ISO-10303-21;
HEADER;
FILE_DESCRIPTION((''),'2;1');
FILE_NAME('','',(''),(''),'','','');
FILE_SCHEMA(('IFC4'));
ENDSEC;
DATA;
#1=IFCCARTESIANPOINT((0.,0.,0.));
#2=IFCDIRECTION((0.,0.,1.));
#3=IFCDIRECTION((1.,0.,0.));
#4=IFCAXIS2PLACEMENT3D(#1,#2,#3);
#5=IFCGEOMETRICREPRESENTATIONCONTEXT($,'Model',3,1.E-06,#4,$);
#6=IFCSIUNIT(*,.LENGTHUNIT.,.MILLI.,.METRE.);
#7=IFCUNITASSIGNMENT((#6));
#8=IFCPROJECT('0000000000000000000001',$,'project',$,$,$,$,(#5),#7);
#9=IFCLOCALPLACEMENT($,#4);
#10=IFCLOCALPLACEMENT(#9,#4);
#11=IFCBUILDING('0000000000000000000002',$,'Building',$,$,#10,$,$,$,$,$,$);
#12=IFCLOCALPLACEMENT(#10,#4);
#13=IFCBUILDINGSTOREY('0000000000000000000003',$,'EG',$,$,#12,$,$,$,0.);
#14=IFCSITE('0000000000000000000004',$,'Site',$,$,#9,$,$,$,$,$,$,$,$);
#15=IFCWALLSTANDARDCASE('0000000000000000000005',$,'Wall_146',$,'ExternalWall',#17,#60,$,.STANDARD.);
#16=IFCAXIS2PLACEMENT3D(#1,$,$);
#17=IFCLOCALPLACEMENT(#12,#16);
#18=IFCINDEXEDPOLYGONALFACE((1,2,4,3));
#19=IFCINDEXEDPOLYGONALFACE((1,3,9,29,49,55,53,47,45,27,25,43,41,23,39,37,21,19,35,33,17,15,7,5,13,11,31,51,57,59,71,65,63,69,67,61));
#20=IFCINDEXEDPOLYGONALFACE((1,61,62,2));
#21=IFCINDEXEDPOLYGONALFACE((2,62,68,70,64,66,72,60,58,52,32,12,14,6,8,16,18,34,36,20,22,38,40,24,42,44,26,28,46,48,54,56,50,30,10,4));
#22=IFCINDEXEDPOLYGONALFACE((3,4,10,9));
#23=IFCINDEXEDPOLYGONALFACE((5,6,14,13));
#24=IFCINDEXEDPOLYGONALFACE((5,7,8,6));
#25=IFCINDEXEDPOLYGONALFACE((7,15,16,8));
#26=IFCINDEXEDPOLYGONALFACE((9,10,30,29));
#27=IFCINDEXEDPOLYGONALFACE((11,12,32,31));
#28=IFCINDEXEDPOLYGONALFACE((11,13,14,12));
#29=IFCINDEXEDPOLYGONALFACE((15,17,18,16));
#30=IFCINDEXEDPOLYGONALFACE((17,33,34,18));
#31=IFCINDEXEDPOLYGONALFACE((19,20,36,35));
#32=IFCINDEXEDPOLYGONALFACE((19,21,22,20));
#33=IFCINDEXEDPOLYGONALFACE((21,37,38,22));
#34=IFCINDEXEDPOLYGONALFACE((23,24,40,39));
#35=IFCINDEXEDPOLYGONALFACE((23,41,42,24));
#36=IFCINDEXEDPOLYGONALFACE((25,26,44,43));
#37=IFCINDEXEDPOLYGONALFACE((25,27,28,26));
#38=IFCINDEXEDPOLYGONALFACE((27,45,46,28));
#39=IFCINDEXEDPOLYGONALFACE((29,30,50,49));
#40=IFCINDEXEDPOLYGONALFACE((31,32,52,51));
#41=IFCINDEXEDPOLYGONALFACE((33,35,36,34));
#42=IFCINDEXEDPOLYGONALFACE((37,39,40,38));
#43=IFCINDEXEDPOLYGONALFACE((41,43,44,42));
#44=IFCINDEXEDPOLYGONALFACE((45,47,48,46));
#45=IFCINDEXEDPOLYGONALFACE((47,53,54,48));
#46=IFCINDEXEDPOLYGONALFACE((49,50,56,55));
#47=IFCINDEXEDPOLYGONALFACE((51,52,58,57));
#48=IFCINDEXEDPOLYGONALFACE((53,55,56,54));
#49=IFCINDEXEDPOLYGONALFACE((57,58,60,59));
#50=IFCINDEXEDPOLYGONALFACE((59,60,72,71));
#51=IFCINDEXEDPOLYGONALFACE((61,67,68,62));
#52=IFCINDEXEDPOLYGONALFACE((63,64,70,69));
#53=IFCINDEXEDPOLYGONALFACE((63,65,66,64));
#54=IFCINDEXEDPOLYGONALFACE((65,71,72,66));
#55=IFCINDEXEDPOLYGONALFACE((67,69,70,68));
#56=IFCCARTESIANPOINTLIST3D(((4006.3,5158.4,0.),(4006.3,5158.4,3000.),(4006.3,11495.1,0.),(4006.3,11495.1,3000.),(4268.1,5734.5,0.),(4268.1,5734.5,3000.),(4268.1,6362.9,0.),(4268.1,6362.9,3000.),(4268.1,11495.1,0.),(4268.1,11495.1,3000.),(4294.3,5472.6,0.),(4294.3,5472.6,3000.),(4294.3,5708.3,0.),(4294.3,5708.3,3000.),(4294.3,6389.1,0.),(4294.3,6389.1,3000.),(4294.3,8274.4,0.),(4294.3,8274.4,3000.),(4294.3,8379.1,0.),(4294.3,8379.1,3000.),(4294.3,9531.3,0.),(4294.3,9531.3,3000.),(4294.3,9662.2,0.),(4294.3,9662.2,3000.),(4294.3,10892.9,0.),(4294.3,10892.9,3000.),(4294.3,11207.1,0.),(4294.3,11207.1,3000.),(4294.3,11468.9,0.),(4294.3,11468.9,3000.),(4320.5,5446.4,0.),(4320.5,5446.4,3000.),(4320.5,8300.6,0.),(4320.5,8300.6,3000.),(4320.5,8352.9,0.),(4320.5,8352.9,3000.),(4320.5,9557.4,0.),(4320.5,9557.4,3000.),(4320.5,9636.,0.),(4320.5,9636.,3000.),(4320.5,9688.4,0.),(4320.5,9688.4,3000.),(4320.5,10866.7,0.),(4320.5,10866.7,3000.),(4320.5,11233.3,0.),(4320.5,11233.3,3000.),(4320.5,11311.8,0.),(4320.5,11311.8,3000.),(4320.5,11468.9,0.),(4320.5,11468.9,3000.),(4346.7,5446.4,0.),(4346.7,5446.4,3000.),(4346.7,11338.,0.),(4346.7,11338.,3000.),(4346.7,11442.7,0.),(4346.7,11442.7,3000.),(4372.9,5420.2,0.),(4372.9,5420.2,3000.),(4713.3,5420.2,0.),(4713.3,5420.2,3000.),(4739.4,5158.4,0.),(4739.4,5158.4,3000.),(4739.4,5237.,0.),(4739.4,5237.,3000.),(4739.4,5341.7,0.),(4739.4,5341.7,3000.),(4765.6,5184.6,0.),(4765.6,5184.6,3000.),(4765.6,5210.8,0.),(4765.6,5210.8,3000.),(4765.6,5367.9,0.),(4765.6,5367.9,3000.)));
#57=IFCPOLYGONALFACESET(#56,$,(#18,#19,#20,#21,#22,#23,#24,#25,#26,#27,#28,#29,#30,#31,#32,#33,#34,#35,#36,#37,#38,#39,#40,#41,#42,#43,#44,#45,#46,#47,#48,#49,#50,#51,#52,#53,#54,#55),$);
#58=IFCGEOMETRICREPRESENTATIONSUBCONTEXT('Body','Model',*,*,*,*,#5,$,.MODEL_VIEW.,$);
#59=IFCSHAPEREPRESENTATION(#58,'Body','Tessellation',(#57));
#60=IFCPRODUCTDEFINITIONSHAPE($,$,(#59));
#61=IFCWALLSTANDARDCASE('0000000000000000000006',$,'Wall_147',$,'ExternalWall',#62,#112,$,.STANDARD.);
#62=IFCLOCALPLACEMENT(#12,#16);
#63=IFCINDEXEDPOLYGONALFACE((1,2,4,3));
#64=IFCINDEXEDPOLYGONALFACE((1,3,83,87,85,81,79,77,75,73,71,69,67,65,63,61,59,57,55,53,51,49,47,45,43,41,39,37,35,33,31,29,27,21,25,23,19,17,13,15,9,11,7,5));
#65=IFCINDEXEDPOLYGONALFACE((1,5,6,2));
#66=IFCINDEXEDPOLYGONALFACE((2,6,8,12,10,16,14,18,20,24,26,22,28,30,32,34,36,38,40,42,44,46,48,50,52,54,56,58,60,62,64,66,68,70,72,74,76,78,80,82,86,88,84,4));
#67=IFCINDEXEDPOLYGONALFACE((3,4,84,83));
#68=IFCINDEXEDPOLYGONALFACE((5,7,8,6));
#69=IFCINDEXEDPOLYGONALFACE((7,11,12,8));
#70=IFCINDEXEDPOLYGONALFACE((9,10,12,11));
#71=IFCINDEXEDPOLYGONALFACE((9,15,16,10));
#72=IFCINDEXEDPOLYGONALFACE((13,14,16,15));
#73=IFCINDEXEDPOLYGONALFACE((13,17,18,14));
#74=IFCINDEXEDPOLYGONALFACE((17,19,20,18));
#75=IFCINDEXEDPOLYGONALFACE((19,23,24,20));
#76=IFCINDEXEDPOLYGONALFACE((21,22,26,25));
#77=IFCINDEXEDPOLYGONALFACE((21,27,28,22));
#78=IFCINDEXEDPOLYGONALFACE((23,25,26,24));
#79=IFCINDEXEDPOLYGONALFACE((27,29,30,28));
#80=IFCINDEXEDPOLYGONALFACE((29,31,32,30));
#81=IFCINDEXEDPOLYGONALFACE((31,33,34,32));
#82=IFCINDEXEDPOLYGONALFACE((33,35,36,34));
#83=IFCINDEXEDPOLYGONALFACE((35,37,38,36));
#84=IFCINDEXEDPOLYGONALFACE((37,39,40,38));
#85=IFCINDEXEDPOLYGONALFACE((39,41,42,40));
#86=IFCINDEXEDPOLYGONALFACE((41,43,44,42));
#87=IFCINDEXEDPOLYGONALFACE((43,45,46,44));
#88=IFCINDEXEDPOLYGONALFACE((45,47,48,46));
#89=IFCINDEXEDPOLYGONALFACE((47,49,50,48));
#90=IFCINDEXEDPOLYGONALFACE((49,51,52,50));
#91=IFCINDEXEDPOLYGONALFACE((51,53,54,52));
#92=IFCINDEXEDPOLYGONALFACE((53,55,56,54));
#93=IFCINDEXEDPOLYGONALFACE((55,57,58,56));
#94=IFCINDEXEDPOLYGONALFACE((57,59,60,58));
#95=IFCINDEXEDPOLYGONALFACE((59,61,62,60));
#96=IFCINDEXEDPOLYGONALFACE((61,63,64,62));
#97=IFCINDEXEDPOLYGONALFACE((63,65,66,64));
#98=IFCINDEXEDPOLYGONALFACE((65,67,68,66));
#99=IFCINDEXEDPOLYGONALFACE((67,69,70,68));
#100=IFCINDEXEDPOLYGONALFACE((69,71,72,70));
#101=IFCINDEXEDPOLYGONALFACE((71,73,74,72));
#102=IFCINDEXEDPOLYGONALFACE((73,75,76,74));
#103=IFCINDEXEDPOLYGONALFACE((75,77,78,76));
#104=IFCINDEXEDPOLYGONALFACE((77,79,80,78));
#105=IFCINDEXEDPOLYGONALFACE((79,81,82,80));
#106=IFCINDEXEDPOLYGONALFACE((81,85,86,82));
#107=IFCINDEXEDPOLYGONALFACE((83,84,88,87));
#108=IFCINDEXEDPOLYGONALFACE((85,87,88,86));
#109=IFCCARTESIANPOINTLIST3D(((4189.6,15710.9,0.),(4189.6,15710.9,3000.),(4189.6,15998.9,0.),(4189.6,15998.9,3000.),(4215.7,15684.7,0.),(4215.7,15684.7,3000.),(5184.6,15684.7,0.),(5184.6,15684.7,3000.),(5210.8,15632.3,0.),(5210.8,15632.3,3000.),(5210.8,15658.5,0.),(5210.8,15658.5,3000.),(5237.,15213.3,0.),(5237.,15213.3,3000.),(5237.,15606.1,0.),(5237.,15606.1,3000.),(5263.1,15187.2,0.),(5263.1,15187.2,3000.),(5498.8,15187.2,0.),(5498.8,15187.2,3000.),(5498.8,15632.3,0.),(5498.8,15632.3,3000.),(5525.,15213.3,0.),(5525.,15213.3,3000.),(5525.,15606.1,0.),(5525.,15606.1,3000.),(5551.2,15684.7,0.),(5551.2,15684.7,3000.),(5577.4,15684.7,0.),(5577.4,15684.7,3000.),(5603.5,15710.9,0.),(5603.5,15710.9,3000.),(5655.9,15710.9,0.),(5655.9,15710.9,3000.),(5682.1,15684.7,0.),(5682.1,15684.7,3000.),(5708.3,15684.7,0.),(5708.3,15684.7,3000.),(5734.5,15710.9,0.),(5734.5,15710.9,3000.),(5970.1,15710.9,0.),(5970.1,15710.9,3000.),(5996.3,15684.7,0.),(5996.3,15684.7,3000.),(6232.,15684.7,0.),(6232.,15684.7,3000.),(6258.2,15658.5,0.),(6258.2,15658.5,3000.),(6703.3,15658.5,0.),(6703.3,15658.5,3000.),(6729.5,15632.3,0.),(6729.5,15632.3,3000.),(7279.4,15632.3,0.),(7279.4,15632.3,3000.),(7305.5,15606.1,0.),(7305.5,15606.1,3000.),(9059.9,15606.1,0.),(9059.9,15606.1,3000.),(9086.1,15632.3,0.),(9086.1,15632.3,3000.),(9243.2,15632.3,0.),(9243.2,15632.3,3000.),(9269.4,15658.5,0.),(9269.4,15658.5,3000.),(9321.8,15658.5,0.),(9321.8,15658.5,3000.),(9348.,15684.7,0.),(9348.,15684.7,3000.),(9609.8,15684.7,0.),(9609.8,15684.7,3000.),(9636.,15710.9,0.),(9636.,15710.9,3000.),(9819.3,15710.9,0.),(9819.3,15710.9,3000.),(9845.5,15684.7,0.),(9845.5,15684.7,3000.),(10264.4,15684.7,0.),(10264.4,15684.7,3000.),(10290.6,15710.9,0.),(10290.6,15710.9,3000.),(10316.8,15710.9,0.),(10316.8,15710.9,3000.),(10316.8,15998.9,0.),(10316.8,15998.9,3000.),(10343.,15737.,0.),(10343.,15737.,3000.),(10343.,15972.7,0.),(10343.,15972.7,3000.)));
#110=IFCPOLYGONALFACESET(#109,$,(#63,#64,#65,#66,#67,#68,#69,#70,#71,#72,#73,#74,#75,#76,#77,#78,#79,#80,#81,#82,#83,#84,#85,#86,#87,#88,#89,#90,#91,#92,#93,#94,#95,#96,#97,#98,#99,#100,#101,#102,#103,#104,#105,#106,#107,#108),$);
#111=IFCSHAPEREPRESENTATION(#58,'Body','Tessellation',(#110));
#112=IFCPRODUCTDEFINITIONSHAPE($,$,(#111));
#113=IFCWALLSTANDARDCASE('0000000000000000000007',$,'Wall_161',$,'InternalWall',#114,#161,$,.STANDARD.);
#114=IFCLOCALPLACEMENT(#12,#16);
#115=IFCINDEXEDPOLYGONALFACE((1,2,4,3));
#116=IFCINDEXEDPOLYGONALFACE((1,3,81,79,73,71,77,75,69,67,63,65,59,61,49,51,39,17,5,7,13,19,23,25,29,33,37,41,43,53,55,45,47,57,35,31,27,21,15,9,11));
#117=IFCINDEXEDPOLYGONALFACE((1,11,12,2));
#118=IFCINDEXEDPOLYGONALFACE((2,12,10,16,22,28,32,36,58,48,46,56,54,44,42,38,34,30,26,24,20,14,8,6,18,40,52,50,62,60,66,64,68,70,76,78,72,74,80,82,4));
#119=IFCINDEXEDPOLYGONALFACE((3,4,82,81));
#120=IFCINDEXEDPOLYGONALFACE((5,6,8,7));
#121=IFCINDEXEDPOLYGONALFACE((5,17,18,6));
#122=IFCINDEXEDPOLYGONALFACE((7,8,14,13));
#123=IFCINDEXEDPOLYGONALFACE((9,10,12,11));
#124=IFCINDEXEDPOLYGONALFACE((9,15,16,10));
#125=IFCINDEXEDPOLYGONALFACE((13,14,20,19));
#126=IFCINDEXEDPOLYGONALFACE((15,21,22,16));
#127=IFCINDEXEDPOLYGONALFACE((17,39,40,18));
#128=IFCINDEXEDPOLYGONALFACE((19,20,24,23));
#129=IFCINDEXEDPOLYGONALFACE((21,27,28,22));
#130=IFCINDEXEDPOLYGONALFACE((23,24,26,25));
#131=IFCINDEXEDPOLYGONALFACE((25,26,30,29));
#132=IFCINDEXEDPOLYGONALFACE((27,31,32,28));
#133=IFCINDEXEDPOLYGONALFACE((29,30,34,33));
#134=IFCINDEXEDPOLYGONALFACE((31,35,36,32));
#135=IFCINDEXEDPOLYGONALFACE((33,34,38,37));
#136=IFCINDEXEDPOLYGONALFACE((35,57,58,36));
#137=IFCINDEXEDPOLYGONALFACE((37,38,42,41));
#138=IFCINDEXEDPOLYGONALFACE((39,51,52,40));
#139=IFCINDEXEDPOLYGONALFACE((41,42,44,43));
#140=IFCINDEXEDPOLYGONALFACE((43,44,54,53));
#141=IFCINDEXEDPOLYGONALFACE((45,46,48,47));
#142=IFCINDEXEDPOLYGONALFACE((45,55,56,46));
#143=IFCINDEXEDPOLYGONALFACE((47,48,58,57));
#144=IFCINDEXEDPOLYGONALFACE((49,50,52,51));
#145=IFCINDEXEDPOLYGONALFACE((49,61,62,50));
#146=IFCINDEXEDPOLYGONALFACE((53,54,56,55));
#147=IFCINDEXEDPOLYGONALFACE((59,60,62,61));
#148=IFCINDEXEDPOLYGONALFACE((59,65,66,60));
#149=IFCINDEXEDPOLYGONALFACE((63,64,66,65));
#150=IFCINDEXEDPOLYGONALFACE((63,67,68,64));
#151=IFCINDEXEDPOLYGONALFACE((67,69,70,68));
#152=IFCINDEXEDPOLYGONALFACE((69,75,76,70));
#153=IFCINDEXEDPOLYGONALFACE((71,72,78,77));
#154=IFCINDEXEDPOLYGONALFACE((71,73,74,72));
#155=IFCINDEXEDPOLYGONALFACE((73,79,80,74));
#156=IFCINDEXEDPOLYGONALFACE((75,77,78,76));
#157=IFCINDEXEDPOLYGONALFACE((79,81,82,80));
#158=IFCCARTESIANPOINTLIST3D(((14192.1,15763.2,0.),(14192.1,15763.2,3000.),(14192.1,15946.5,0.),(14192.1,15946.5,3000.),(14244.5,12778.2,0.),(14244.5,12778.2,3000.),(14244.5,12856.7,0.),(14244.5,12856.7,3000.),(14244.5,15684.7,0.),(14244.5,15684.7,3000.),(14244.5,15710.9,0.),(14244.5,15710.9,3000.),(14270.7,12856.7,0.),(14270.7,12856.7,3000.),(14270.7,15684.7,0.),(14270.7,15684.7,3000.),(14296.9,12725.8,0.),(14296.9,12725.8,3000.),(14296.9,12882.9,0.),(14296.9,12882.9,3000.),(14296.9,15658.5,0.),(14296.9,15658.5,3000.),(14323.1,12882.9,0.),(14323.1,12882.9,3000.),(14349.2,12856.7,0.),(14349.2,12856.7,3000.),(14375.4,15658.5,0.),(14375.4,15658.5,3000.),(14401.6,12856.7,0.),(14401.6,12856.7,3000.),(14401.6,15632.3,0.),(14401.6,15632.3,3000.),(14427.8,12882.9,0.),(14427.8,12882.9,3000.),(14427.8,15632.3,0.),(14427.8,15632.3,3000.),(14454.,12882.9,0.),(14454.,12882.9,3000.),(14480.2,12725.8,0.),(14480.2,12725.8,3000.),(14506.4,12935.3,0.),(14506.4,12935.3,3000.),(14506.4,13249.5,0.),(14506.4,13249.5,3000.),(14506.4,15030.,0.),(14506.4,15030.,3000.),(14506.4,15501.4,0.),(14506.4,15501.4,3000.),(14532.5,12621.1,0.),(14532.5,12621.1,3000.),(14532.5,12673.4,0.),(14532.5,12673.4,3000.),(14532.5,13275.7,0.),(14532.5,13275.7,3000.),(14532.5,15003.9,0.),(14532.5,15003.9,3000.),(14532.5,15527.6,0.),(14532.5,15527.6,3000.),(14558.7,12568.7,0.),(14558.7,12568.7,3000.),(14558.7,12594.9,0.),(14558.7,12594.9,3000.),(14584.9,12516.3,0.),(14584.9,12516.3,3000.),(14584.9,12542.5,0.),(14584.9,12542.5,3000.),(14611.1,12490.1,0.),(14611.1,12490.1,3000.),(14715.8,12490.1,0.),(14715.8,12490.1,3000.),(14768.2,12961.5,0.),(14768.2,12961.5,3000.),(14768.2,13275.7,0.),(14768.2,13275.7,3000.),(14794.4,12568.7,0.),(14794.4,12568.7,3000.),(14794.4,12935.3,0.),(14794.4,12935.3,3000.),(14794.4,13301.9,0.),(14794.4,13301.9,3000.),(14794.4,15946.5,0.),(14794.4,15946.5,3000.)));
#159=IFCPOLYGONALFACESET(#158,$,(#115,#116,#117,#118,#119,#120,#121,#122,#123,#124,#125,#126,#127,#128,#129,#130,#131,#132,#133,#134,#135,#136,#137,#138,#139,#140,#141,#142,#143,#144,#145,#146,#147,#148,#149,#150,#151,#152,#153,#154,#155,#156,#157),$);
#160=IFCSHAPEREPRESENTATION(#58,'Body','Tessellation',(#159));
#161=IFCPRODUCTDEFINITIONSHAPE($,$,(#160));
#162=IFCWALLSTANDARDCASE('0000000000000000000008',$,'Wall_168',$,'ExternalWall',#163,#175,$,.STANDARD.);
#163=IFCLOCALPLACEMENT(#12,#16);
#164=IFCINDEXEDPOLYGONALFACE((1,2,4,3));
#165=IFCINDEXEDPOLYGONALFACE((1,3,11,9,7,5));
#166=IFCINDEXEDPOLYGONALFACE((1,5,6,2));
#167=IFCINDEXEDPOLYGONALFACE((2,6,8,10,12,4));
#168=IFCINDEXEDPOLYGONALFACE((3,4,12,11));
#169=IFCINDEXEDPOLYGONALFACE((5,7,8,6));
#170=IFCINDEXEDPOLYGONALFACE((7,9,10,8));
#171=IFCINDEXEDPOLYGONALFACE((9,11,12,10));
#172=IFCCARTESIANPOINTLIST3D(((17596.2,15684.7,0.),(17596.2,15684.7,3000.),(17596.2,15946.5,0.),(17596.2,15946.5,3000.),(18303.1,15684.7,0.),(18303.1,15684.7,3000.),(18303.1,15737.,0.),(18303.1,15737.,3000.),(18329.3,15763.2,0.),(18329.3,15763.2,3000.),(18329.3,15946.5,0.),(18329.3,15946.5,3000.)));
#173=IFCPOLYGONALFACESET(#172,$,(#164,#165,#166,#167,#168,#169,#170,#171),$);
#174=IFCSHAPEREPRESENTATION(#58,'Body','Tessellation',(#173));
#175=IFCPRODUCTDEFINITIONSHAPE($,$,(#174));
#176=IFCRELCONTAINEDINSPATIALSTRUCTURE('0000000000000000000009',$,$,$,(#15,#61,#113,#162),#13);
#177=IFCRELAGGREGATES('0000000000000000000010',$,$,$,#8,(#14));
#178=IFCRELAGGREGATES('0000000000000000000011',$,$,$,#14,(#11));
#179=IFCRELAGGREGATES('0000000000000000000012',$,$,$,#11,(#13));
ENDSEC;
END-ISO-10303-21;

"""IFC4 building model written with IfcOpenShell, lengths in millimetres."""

from ifc_helpers import new_model, si_unit, frame, origin_with_axes, place, context, subcontext, project, spatial, polyline, outline, extrude, element, save


model = new_model("IFC4")

# Units and contexts
model_context = context("Model", 3, precision=1e-06, world=origin_with_axes())
body_context = subcontext(model_context, "Body", "Model", "MODEL_VIEW")
ifc_project = project(units=[si_unit("LENGTHUNIT", "METRE", prefix="MILLI")], contexts=[model_context])

# Site, building, storey
site_placement = place(None, origin_with_axes())
site = spatial("IfcSite", under=ifc_project, at=site_placement, Name="Site")
building_placement = place(site_placement, origin_with_axes())
building = spatial("IfcBuilding", under=site, at=building_placement, Name="Building")
storey_placement = place(building_placement, origin_with_axes())
storey = spatial("IfcBuildingStorey", under=building, at=storey_placement, Name="EG", Elevation=0.0)

# Walls
wall_1_placement = place(storey_placement, origin_with_axes())
element("IfcWallStandardCase", 1, at=wall_1_placement, inside=storey, Name="Wall_146", ObjectType="ExternalWall", PredefinedType="STANDARD", context=body_context, shape_type="SweptSolid", body=[
    extrude(outline(polyline([(4006.3, 5158.4, 0.0), (4006.3, 11495.1, 0.0), (4268.1, 11495.1, 0.0), (4294.3, 11468.9, 0.0), (4320.5, 11468.9, 0.0), (4346.7, 11442.7, 0.0), (4346.7, 11338.0, 0.0), (4320.5, 11311.8, 0.0), (4320.5, 11233.3, 0.0), (4294.3, 11207.1, 0.0), (4294.3, 10892.9, 0.0), (4320.5, 10866.7, 0.0), (4320.5, 9688.4, 0.0), (4294.3, 9662.2, 0.0), (4320.5, 9636.0, 0.0), (4320.5, 9557.4, 0.0), (4294.3, 9531.3, 0.0), (4294.3, 8379.1, 0.0), (4320.5, 8352.9, 0.0), (4320.5, 8300.6, 0.0), (4294.3, 8274.4, 0.0), (4294.3, 6389.1, 0.0), (4268.1, 6362.9, 0.0), (4268.1, 5734.5, 0.0), (4294.3, 5708.3, 0.0), (4294.3, 5472.6, 0.0), (4320.5, 5446.4, 0.0), (4346.7, 5446.4, 0.0), (4372.9, 5420.2, 0.0), (4713.3, 5420.2, 0.0), (4765.6, 5367.9, 0.0), (4739.4, 5341.7, 0.0), (4739.4, 5237.0, 0.0), (4765.6, 5210.8, 0.0), (4765.6, 5184.6, 0.0), (4739.4, 5158.4, 0.0), (4006.3, 5158.4, 0.0)])), origin_with_axes(), (0.0, 0.0, 1.0), 3000.0),
])
wall_2_placement = place(storey_placement, origin_with_axes())
element("IfcWallStandardCase", 2, at=wall_2_placement, inside=storey, Name="Wall_147", ObjectType="ExternalWall", PredefinedType="STANDARD", context=body_context, shape_type="SweptSolid", body=[
    extrude(outline(polyline([(5263.1, 15187.2, 0.0), (5237.0, 15213.3, 0.0), (5237.0, 15606.1, 0.0), (5210.8, 15632.3, 0.0), (5210.8, 15658.5, 0.0), (5184.6, 15684.7, 0.0), (4215.7, 15684.7, 0.0), (4189.6, 15710.9, 0.0), (4189.6, 15998.9, 0.0), (10316.8, 15998.9, 0.0), (10343.0, 15972.7, 0.0), (10343.0, 15737.0, 0.0), (10316.8, 15710.9, 0.0), (10290.6, 15710.9, 0.0), (10264.4, 15684.7, 0.0), (9845.5, 15684.7, 0.0), (9819.3, 15710.9, 0.0), (9636.0, 15710.9, 0.0), (9609.8, 15684.7, 0.0), (9348.0, 15684.7, 0.0), (9321.8, 15658.5, 0.0), (9269.4, 15658.5, 0.0), (9243.2, 15632.3, 0.0), (9086.1, 15632.3, 0.0), (9059.9, 15606.1, 0.0), (7305.5, 15606.1, 0.0), (7279.4, 15632.3, 0.0), (6729.5, 15632.3, 0.0), (6703.3, 15658.5, 0.0), (6258.2, 15658.5, 0.0), (6232.0, 15684.7, 0.0), (5996.3, 15684.7, 0.0), (5970.1, 15710.9, 0.0), (5734.5, 15710.9, 0.0), (5708.3, 15684.7, 0.0), (5682.1, 15684.7, 0.0), (5655.9, 15710.9, 0.0), (5603.5, 15710.9, 0.0), (5577.4, 15684.7, 0.0), (5551.2, 15684.7, 0.0), (5498.8, 15632.3, 0.0), (5525.0, 15606.1, 0.0), (5525.0, 15213.3, 0.0), (5498.8, 15187.2, 0.0), (5263.1, 15187.2, 0.0)])), origin_with_axes(), (0.0, 0.0, 1.0), 3000.0),
])
wall_3_placement = place(storey_placement, origin_with_axes())
element("IfcWallStandardCase", 3, at=wall_3_placement, inside=storey, Name="Wall_161", ObjectType="InternalWall", PredefinedType="STANDARD", context=body_context, shape_type="SweptSolid", body=[
    extrude(outline(polyline([(14611.1, 12490.1, 0.0), (14584.9, 12516.3, 0.0), (14584.9, 12542.5, 0.0), (14558.7, 12568.7, 0.0), (14558.7, 12594.9, 0.0), (14532.5, 12621.1, 0.0), (14532.5, 12673.4, 0.0), (14480.2, 12725.8, 0.0), (14296.9, 12725.8, 0.0), (14244.5, 12778.2, 0.0), (14244.5, 12856.7, 0.0), (14270.7, 12856.7, 0.0), (14296.9, 12882.9, 0.0), (14323.1, 12882.9, 0.0), (14349.2, 12856.7, 0.0), (14401.6, 12856.7, 0.0), (14427.8, 12882.9, 0.0), (14454.0, 12882.9, 0.0), (14506.4, 12935.3, 0.0), (14506.4, 13249.5, 0.0), (14532.5, 13275.7, 0.0), (14532.5, 15003.9, 0.0), (14506.4, 15030.0, 0.0), (14506.4, 15501.4, 0.0), (14532.5, 15527.6, 0.0), (14427.8, 15632.3, 0.0), (14401.6, 15632.3, 0.0), (14375.4, 15658.5, 0.0), (14296.9, 15658.5, 0.0), (14270.7, 15684.7, 0.0), (14244.5, 15684.7, 0.0), (14244.5, 15710.9, 0.0), (14192.1, 15763.2, 0.0), (14192.1, 15946.5, 0.0), (14794.4, 15946.5, 0.0), (14794.4, 13301.9, 0.0), (14768.2, 13275.7, 0.0), (14768.2, 12961.5, 0.0), (14794.4, 12935.3, 0.0), (14794.4, 12568.7, 0.0), (14715.8, 12490.1, 0.0), (14611.1, 12490.1, 0.0)])), origin_with_axes(), (0.0, 0.0, 1.0), 3000.0),
])
for number, where, z_axis, x_axis, name in (
    (4, (0.0, 0.0, 0.0), (0.0, 0.0, 1.0), (1.0, 0.0, 0.0), "Wall_168"),
):
    element("IfcWallStandardCase", number, at=place(storey_placement, frame(where, z_axis=z_axis, x_axis=x_axis)), inside=storey, Name=name, ObjectType="ExternalWall", PredefinedType="STANDARD", context=body_context, shape_type="SweptSolid", body=[
        extrude(outline(polyline([(17596.2, 15684.7, 0.0), (17596.2, 15946.5, 0.0), (18329.3, 15946.5, 0.0), (18329.3, 15763.2, 0.0), (18303.1, 15737.0, 0.0), (18303.1, 15684.7, 0.0), (17596.2, 15684.7, 0.0)])), origin_with_axes(), (0.0, 0.0, 1.0), 3000.0),
    ])

save(model, "model.ifc")
